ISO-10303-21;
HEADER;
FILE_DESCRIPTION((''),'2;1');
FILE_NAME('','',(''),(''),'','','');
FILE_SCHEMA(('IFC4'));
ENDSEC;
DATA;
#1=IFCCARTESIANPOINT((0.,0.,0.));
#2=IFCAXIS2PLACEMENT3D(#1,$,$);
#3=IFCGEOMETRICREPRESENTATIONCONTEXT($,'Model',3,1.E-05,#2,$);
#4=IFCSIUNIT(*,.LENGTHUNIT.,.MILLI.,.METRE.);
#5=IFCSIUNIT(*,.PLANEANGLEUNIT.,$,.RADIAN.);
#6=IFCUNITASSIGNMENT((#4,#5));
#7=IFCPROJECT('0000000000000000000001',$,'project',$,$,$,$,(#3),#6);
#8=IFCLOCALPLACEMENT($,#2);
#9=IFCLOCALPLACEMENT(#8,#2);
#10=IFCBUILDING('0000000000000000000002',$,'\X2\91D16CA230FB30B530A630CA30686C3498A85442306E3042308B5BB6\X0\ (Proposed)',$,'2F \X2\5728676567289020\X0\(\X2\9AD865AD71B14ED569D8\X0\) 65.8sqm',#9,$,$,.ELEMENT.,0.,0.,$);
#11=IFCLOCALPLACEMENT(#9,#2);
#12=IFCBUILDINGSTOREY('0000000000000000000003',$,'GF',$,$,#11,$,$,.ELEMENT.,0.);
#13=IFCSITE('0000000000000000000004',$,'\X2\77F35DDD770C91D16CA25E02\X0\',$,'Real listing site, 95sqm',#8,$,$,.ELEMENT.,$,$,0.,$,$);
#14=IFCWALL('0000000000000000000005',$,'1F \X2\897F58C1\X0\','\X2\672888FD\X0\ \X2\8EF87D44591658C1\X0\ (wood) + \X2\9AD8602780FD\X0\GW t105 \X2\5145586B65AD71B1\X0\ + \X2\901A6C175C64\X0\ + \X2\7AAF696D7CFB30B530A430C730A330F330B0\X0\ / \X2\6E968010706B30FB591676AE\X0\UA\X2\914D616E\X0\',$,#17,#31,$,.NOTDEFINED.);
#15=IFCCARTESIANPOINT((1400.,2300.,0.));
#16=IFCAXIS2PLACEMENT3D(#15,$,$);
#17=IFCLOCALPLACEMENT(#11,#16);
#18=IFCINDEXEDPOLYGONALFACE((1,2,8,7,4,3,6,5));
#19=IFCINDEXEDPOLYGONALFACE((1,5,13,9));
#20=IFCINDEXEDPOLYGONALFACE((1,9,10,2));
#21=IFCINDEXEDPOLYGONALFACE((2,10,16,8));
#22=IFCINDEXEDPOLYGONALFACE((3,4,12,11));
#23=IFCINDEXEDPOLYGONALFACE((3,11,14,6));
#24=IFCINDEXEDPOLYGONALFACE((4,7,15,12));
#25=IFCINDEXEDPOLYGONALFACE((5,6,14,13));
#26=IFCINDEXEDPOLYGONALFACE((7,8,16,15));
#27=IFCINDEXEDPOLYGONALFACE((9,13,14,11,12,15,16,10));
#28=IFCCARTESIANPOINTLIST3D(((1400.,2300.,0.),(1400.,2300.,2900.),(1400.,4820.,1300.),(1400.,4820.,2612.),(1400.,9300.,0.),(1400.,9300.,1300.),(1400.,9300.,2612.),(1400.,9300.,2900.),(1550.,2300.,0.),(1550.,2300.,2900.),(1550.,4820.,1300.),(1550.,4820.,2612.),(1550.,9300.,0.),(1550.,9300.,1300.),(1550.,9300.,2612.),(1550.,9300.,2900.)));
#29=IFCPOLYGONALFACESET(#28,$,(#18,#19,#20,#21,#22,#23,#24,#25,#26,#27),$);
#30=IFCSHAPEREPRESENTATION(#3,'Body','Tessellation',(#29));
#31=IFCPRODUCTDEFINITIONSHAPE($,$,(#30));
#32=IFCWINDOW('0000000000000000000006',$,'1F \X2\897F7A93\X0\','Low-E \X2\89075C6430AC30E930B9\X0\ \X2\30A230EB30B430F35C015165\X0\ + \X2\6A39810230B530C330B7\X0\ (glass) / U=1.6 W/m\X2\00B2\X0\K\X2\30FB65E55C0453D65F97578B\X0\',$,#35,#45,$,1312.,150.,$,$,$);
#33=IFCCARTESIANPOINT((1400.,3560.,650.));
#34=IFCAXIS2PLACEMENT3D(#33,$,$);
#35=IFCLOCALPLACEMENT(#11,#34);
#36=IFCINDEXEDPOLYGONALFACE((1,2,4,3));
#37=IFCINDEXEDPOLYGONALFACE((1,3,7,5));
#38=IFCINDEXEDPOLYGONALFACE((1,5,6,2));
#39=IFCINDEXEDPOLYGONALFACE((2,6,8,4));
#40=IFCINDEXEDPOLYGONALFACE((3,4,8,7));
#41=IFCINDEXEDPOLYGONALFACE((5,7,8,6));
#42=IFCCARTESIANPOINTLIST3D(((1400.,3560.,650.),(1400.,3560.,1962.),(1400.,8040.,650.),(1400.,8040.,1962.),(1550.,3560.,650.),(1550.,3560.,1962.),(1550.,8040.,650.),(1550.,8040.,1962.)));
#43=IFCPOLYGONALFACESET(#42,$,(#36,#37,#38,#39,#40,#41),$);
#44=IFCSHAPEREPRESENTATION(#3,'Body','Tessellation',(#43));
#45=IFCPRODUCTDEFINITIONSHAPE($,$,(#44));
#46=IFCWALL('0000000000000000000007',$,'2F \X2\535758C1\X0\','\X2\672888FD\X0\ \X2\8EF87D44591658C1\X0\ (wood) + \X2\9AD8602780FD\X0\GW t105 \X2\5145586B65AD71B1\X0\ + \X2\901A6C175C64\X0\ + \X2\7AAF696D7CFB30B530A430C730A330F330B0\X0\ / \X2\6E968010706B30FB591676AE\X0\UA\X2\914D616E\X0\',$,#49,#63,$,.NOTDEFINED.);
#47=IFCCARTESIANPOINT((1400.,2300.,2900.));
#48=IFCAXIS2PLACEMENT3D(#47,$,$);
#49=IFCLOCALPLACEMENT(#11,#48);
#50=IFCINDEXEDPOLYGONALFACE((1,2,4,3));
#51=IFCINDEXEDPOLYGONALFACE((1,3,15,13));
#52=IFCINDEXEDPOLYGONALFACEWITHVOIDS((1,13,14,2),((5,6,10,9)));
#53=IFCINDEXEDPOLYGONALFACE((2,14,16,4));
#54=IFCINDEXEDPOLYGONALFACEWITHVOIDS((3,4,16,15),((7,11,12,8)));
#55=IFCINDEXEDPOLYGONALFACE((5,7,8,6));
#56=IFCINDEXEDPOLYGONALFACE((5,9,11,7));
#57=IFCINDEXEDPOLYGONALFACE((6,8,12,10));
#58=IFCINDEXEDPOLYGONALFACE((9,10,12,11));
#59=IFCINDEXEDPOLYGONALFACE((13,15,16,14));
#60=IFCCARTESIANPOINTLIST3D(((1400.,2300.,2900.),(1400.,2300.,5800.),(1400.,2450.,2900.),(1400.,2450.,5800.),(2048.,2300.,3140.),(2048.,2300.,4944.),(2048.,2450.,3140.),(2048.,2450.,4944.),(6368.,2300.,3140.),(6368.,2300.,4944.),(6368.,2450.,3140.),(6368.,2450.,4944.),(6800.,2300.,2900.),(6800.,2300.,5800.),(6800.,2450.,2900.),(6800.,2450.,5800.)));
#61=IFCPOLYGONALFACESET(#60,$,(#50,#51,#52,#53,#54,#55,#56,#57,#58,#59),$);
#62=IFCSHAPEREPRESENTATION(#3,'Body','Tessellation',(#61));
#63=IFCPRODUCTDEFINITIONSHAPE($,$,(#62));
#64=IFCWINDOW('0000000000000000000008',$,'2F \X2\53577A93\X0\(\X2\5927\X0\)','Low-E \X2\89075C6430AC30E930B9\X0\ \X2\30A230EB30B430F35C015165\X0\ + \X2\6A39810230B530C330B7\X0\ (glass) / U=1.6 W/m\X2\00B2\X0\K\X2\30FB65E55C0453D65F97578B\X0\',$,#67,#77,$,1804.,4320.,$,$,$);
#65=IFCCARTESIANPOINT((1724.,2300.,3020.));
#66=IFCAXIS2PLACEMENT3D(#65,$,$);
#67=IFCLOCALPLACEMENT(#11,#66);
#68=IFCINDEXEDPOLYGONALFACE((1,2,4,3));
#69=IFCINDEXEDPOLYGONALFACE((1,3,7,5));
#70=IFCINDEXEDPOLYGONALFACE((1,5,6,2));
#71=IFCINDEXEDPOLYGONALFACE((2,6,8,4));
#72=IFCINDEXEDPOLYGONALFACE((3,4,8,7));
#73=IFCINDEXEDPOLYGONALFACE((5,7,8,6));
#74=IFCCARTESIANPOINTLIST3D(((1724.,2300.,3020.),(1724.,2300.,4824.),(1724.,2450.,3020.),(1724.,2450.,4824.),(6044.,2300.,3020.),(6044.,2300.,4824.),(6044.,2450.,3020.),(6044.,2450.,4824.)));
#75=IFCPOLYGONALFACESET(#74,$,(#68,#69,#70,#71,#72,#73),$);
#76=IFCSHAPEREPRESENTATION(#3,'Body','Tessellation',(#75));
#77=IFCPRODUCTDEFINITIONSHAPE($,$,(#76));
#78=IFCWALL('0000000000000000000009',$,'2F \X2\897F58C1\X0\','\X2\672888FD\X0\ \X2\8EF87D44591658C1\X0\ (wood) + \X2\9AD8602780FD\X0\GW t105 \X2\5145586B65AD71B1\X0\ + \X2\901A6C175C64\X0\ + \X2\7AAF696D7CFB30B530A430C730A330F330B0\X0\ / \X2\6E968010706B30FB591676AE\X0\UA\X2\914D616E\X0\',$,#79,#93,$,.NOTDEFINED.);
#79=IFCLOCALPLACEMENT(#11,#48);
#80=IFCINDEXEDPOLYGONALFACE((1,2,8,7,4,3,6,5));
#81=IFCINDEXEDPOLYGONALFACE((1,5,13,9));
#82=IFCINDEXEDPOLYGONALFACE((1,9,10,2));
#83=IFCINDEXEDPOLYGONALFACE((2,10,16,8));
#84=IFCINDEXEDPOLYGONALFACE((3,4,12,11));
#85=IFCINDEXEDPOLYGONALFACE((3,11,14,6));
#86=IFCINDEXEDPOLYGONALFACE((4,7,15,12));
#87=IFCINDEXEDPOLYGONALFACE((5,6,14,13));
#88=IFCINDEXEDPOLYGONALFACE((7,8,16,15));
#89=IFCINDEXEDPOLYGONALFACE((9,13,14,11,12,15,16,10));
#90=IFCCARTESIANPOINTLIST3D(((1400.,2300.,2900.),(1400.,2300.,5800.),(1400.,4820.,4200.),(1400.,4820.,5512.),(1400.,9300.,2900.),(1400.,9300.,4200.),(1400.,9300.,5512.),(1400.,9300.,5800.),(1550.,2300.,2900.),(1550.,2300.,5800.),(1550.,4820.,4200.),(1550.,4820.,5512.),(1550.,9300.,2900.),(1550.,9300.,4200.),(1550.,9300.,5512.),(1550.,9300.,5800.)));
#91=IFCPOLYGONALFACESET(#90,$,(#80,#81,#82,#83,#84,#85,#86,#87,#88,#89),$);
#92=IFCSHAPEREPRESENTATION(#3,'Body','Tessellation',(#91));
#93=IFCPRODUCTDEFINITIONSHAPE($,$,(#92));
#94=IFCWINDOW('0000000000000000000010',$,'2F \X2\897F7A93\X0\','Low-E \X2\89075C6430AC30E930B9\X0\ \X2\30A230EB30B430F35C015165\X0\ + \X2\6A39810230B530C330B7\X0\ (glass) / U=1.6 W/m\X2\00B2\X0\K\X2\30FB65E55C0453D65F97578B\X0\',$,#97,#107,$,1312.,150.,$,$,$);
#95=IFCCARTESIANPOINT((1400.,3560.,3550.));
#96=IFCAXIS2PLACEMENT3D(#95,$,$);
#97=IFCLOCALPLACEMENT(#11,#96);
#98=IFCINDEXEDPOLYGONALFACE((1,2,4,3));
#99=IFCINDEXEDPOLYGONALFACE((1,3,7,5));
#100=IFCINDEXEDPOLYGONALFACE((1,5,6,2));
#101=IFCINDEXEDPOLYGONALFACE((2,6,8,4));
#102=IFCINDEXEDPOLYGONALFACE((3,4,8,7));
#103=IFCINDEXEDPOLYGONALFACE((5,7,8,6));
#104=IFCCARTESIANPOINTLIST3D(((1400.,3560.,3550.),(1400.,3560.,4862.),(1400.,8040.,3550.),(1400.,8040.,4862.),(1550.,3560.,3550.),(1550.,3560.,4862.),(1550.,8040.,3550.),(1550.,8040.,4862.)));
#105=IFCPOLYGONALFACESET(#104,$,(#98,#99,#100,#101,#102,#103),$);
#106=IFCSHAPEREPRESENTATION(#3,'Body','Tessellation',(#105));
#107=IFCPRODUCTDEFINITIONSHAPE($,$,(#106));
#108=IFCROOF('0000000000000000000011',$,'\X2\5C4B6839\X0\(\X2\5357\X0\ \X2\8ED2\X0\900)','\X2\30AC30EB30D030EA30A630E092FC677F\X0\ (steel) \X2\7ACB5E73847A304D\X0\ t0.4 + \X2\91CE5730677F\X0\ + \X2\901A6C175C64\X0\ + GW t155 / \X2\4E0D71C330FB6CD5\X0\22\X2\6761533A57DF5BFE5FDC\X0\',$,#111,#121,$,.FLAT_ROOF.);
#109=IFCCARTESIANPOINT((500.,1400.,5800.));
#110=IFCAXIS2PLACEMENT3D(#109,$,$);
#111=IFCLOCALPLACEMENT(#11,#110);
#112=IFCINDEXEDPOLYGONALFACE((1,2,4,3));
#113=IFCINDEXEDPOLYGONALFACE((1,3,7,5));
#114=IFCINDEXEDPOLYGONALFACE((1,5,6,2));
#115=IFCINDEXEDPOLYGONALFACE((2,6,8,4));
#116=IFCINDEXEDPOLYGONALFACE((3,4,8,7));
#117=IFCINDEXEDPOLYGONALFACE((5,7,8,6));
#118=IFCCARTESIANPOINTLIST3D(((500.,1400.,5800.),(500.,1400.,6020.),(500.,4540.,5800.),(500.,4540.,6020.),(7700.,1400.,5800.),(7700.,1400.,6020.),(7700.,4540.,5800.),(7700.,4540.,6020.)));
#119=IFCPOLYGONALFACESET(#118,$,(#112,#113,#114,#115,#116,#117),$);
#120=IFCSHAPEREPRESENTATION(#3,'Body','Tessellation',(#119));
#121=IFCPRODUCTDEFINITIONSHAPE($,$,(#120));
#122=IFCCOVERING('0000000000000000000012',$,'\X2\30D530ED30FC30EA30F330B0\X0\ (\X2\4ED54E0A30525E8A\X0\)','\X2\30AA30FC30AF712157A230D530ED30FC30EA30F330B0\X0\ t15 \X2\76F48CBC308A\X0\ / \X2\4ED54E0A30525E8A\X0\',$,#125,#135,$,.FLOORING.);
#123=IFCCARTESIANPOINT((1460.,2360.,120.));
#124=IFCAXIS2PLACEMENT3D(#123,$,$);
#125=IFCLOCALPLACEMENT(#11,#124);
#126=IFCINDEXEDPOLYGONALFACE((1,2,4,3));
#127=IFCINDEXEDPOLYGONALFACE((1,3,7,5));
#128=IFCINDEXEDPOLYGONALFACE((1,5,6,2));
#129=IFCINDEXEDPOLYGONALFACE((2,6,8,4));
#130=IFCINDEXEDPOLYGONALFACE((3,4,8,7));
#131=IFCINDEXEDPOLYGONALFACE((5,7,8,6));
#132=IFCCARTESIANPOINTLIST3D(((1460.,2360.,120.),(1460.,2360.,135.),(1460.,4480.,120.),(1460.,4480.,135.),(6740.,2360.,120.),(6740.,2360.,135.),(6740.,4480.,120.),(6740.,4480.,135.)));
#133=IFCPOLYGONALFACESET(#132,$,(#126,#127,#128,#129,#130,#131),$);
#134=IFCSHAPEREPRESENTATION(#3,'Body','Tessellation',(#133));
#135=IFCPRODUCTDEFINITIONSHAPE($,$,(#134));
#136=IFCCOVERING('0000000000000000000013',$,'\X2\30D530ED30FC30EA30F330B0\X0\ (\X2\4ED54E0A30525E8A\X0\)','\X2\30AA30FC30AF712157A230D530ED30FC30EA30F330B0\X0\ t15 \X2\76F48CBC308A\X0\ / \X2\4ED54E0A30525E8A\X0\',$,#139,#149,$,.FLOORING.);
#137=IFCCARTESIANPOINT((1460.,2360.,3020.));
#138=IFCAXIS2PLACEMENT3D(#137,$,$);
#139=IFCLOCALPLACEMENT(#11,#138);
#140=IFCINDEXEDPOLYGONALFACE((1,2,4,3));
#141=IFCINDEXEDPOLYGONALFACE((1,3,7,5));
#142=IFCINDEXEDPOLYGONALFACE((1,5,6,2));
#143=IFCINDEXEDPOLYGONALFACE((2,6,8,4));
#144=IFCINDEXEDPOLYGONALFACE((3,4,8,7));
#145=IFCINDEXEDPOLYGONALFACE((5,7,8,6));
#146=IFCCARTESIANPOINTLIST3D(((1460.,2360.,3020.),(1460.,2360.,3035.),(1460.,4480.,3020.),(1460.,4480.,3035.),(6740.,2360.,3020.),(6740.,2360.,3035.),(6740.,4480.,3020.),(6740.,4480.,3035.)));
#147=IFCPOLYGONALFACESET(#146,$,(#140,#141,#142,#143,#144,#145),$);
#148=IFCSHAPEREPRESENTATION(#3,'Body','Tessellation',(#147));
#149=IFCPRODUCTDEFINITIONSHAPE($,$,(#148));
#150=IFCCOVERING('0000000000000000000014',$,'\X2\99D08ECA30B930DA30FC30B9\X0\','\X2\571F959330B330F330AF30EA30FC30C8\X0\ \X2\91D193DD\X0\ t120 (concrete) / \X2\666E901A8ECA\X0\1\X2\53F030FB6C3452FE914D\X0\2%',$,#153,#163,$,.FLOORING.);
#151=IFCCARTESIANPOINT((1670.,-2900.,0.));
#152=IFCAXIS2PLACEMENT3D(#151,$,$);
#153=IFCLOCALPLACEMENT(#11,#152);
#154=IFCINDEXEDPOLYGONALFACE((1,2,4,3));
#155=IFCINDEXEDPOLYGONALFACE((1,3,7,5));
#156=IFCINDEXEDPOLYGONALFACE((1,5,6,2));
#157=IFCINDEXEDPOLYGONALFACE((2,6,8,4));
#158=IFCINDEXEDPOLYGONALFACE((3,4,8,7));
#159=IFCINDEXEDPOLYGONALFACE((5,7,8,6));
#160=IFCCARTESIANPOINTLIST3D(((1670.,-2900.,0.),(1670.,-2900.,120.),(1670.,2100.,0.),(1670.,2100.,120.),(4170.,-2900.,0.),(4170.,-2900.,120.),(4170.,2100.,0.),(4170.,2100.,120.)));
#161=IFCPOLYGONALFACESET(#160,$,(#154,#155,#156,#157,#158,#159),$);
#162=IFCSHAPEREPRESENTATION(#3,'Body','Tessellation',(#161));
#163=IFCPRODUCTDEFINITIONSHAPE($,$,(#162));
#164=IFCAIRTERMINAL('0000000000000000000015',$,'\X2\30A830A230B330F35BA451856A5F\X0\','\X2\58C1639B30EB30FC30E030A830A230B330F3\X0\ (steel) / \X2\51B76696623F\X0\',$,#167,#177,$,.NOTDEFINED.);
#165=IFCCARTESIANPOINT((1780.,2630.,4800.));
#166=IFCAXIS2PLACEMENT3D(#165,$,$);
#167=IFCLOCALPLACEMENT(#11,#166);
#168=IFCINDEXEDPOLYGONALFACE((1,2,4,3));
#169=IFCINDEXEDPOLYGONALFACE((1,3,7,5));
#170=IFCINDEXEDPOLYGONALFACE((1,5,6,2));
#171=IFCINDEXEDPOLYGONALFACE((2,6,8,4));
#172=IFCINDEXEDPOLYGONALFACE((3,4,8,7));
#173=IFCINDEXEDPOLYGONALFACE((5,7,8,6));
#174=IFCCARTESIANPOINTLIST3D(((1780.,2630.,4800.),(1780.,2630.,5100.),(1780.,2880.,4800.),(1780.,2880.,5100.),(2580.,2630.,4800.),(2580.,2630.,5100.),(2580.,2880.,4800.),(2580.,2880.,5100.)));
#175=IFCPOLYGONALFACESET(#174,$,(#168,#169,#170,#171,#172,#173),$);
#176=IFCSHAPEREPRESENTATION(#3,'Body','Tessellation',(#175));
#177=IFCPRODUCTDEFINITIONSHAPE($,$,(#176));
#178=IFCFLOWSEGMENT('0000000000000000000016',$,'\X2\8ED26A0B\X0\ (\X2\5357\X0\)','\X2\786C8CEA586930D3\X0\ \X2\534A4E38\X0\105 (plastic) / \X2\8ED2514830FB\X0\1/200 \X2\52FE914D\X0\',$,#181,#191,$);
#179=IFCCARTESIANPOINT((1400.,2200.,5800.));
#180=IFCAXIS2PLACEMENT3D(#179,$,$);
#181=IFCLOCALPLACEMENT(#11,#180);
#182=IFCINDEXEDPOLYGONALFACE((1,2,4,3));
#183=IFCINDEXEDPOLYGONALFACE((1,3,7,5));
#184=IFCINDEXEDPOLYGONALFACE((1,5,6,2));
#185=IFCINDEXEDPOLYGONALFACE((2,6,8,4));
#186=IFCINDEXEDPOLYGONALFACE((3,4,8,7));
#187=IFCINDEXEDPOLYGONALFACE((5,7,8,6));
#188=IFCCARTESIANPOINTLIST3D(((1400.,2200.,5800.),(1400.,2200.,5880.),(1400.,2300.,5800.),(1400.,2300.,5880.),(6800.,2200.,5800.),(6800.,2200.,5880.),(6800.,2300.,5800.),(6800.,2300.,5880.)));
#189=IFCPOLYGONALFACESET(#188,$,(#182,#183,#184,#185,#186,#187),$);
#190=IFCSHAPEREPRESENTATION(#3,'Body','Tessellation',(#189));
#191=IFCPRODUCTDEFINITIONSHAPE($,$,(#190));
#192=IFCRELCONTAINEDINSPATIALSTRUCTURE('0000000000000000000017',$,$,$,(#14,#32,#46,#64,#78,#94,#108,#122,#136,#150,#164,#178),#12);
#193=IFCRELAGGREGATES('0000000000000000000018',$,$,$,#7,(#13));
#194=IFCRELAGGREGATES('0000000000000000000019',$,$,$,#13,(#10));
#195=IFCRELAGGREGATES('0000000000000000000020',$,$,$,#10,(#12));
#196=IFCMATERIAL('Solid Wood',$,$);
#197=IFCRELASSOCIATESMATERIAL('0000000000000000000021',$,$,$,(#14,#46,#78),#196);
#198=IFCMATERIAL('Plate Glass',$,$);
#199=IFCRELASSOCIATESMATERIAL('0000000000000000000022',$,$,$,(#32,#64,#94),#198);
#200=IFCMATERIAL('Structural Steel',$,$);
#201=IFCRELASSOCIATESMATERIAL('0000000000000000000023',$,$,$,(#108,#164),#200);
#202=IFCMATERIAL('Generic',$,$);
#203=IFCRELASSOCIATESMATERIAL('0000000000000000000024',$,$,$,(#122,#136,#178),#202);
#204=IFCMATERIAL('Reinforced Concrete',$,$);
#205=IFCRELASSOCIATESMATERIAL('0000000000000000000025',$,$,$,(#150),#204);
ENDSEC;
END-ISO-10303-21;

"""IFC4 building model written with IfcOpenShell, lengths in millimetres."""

from ifc_helpers import new_model, si_unit, frame, frame_2d, origin, place, context, project, spatial, rectangle, extrude, material, element, fill, save


model = new_model("IFC4")

# Units and contexts
model_context = context("Model", 3, precision=1e-05, world=origin())
ifc_project = project(units=[si_unit("LENGTHUNIT", "METRE", prefix="MILLI"), si_unit("PLANEANGLEUNIT", "RADIAN")], contexts=[model_context])

# Site, building, storey
site_placement = place(None, origin())
site = spatial("IfcSite", under=ifc_project, at=site_placement, Name="石川県金沢市", ObjectType="Real listing site, 95sqm", CompositionType="ELEMENT", RefElevation=0.0)
building_placement = place(site_placement, origin())
building = spatial("IfcBuilding", under=site, at=building_placement, Name="金沢・サウナと水風呂のある家 (Proposed)", ObjectType="2F 在来木造(高断熱仕様) 65.8sqm", CompositionType="ELEMENT", ElevationOfRefHeight=0.0, ElevationOfTerrain=0.0)
storey_placement = place(building_placement, origin())
storey = spatial("IfcBuildingStorey", under=building, at=storey_placement, Name="GF", CompositionType="ELEMENT", Elevation=0.0)

# Shared definitions
ifc_material_1 = material(Name="Solid Wood")

# Shared definitions
ifc_material_2 = material(Name="Reinforced Concrete")

# Shared definitions
ifc_material_3 = material(Name="Plate Glass")

# Walls, openings, windows
wall_1_placement = place(storey_placement, frame((1400.0, 2300.0, 0.0)))
wall_1 = element("IfcWall", 1, at=wall_1_placement, inside=storey, material=ifc_material_1, Name="1F 西壁", Description="木製 軸組外壁 (wood) + 高性能GW t105 充填断熱 + 通気層 + 窯業系サイディング / 準耐火・外皮UA配慮", PredefinedType="NOTDEFINED", context=model_context, shape_type="SweptSolid", body=[
    extrude(rectangle(XDim=150.0, YDim=7000.0, at=frame_2d((75.0, 3500.0))), frame((1400.0, 2300.0, 0.0)), (0.0, 0.0, 1.0), 2900.0),
])
opening_1_placement = place(storey_placement, frame((1400.0, 3560.0, 650.0)))
opening_1 = element("IfcOpeningElement", 2, at=opening_1_placement, cuts=wall_1, PredefinedType="NOTDEFINED", context=model_context, shape_type="SweptSolid", body=[
    extrude(rectangle(XDim=150.0, YDim=4480.0, at=frame_2d((75.0, 2240.0))), frame((1400.0, 3560.0, 650.0)), (0.0, 0.0, 1.0), 1312.0),
])
window_1_placement = place(storey_placement, frame((1400.0, 3560.0, 650.0)))
window_1 = element("IfcWindow", 3, at=window_1_placement, inside=storey, material=ifc_material_3, Name="1F 西窓", Description="Low-E 複層ガラス アルゴン封入 + 樹脂サッシ (glass) / U=1.6 W/m²K・日射取得型", OverallHeight=1312.0, OverallWidth=150.0, context=model_context, shape_type="SweptSolid", body=[
    extrude(rectangle(XDim=150.0, YDim=4480.0, at=frame_2d((75.0, 2240.0))), frame((1400.0, 3560.0, 650.0)), (0.0, 0.0, 1.0), 1312.0),
])
fill(opening_1, window_1)
wall_2_placement = place(storey_placement, frame((1400.0, 2300.0, 2900.0)))
wall_2 = element("IfcWall", 4, at=wall_2_placement, inside=storey, material=ifc_material_1, Name="2F 南壁", Description="木製 軸組外壁 (wood) + 高性能GW t105 充填断熱 + 通気層 + 窯業系サイディング / 準耐火・外皮UA配慮", PredefinedType="NOTDEFINED", context=model_context, shape_type="SweptSolid", body=[
    extrude(rectangle(XDim=5400.0, YDim=150.0, at=frame_2d((2700.0, 75.0))), frame((1400.0, 2300.0, 2900.0)), (0.0, 0.0, 1.0), 2900.0),
])
opening_2_placement = place(storey_placement, frame((1724.0, 2300.0, 3020.0)))
opening_2 = element("IfcOpeningElement", 5, at=opening_2_placement, cuts=wall_2, PredefinedType="NOTDEFINED", context=model_context, shape_type="SweptSolid", body=[
    extrude(rectangle(XDim=4320.0, YDim=150.0, at=frame_2d((2160.0, 75.0))), frame((1724.0, 2300.0, 3020.0)), (0.0, 0.0, 1.0), 1804.0),
])
window_2_placement = place(storey_placement, frame((1724.0, 2300.0, 3020.0)))
window_2 = element("IfcWindow", 6, at=window_2_placement, inside=storey, material=ifc_material_3, Name="2F 南窓(大)", Description="Low-E 複層ガラス アルゴン封入 + 樹脂サッシ (glass) / U=1.6 W/m²K・日射取得型", OverallHeight=1804.0, OverallWidth=4320.0, context=model_context, shape_type="SweptSolid", body=[
    extrude(rectangle(XDim=4320.0, YDim=150.0, at=frame_2d((2160.0, 75.0))), frame((1724.0, 2300.0, 3020.0)), (0.0, 0.0, 1.0), 1804.0),
])
fill(opening_2, window_2)
wall_3_placement = place(storey_placement, frame((1400.0, 2300.0, 2900.0)))
wall_3 = element("IfcWall", 7, at=wall_3_placement, inside=storey, material=ifc_material_1, Name="2F 西壁", Description="木製 軸組外壁 (wood) + 高性能GW t105 充填断熱 + 通気層 + 窯業系サイディング / 準耐火・外皮UA配慮", PredefinedType="NOTDEFINED", context=model_context, shape_type="SweptSolid", body=[
    extrude(rectangle(XDim=150.0, YDim=7000.0, at=frame_2d((75.0, 3500.0))), frame((1400.0, 2300.0, 2900.0)), (0.0, 0.0, 1.0), 2900.0),
])
opening_3_placement = place(storey_placement, frame((1400.0, 3560.0, 3550.0)))
opening_3 = element("IfcOpeningElement", 8, at=opening_3_placement, cuts=wall_3, PredefinedType="NOTDEFINED", context=model_context, shape_type="SweptSolid", body=[
    extrude(rectangle(XDim=150.0, YDim=4480.0, at=frame_2d((75.0, 2240.0))), frame((1400.0, 3560.0, 3550.0)), (0.0, 0.0, 1.0), 1312.0),
])
window_3_placement = place(storey_placement, frame((1400.0, 3560.0, 3550.0)))
window_3 = element("IfcWindow", 9, at=window_3_placement, inside=storey, material=ifc_material_3, Name="2F 西窓", Description="Low-E 複層ガラス アルゴン封入 + 樹脂サッシ (glass) / U=1.6 W/m²K・日射取得型", OverallHeight=1312.0, OverallWidth=150.0, context=model_context, shape_type="SweptSolid", body=[
    extrude(rectangle(XDim=150.0, YDim=4480.0, at=frame_2d((75.0, 2240.0))), frame((1400.0, 3560.0, 3550.0)), (0.0, 0.0, 1.0), 1312.0),
])
fill(opening_3, window_3)

# Roof
ifc_material_4 = material(Name="Structural Steel")
for number, where, name in (
    (10, (500.0, 1400.0, 5800.0), "屋根(南 軒900)"),
):
    element("IfcRoof", number, at=place(storey_placement, frame(where)), inside=storey, material=ifc_material_4, Name=name, Description="ガルバリウム鋼板 (steel) 立平葺き t0.4 + 野地板 + 通気層 + GW t155 / 不燃・法22条区域対応", PredefinedType="FLAT_ROOF", context=model_context, shape_type="SweptSolid", body=[
        extrude(rectangle(XDim=7200.0, YDim=3140.0, at=frame_2d((3600.0, 1570.0))), frame((500.0, 1400.0, 5800.0)), (0.0, 0.0, 1.0), 220.0),
    ])

# Coverings
ifc_material_5 = material(Name="Generic")
covering_1_placement = place(storey_placement, frame((1460.0, 2360.0, 120.0)))
element("IfcCovering", 11, at=covering_1_placement, inside=storey, material=ifc_material_5, Name="フローリング (仕上げ床)", Description="オーク無垢フローリング t15 直貼り / 仕上げ床", PredefinedType="FLOORING", context=model_context, shape_type="SweptSolid", body=[
    extrude(rectangle(XDim=5280.0, YDim=2120.0, at=frame_2d((2640.0, 1060.0))), frame((1460.0, 2360.0, 120.0)), (0.0, 0.0, 1.0), 15.0),
])
covering_2_placement = place(storey_placement, frame((1460.0, 2360.0, 3020.0)))
element("IfcCovering", 12, at=covering_2_placement, inside=storey, material=ifc_material_5, Name="フローリング (仕上げ床)", Description="オーク無垢フローリング t15 直貼り / 仕上げ床", PredefinedType="FLOORING", context=model_context, shape_type="SweptSolid", body=[
    extrude(rectangle(XDim=5280.0, YDim=2120.0, at=frame_2d((2640.0, 1060.0))), frame((1460.0, 2360.0, 3020.0)), (0.0, 0.0, 1.0), 15.0),
])
covering_3_placement = place(storey_placement, frame((1670.0, -2900.0, 0.0)))
element("IfcCovering", 13, at=covering_3_placement, inside=storey, material=ifc_material_2, Name="駐車スペース", Description="土間コンクリート 金鏝 t120 (concrete) / 普通車1台・水勾配2%", PredefinedType="FLOORING", context=model_context, shape_type="SweptSolid", body=[
    extrude(rectangle(XDim=2500.0, YDim=5000.0, at=frame_2d((1250.0, 2500.0))), frame((1670.0, -2900.0, 0.0)), (0.0, 0.0, 1.0), 120.0),
])

# Air terminal
air_terminal_placement = place(storey_placement, frame((1780.0, 2630.0, 4800.0)))
element("IfcAirTerminal", 14, at=air_terminal_placement, inside=storey, material=ifc_material_4, Name="エアコン室内機", Description="壁掛ルームエアコン (steel) / 冷暖房", PredefinedType="NOTDEFINED", context=model_context, shape_type="SweptSolid", body=[
    extrude(rectangle(XDim=800.0, YDim=250.0, at=frame_2d((400.0, 125.0))), frame((1780.0, 2630.0, 4800.0)), (0.0, 0.0, 1.0), 300.0),
])

# Flow segment
flow_segment_1_placement = place(storey_placement, frame((1400.0, 2200.0, 5800.0)))
element("IfcFlowSegment", 15, at=flow_segment_1_placement, inside=storey, material=ifc_material_5, Name="軒樋 (南)", Description="硬質塩ビ 半丸105 (plastic) / 軒先・1/200 勾配", context=model_context, shape_type="SweptSolid", body=[
    extrude(rectangle(XDim=5400.0, YDim=100.0, at=frame_2d((2700.0, 50.0))), frame((1400.0, 2200.0, 5800.0)), (0.0, 0.0, 1.0), 80.0),
])

save(model, "model.ifc")
